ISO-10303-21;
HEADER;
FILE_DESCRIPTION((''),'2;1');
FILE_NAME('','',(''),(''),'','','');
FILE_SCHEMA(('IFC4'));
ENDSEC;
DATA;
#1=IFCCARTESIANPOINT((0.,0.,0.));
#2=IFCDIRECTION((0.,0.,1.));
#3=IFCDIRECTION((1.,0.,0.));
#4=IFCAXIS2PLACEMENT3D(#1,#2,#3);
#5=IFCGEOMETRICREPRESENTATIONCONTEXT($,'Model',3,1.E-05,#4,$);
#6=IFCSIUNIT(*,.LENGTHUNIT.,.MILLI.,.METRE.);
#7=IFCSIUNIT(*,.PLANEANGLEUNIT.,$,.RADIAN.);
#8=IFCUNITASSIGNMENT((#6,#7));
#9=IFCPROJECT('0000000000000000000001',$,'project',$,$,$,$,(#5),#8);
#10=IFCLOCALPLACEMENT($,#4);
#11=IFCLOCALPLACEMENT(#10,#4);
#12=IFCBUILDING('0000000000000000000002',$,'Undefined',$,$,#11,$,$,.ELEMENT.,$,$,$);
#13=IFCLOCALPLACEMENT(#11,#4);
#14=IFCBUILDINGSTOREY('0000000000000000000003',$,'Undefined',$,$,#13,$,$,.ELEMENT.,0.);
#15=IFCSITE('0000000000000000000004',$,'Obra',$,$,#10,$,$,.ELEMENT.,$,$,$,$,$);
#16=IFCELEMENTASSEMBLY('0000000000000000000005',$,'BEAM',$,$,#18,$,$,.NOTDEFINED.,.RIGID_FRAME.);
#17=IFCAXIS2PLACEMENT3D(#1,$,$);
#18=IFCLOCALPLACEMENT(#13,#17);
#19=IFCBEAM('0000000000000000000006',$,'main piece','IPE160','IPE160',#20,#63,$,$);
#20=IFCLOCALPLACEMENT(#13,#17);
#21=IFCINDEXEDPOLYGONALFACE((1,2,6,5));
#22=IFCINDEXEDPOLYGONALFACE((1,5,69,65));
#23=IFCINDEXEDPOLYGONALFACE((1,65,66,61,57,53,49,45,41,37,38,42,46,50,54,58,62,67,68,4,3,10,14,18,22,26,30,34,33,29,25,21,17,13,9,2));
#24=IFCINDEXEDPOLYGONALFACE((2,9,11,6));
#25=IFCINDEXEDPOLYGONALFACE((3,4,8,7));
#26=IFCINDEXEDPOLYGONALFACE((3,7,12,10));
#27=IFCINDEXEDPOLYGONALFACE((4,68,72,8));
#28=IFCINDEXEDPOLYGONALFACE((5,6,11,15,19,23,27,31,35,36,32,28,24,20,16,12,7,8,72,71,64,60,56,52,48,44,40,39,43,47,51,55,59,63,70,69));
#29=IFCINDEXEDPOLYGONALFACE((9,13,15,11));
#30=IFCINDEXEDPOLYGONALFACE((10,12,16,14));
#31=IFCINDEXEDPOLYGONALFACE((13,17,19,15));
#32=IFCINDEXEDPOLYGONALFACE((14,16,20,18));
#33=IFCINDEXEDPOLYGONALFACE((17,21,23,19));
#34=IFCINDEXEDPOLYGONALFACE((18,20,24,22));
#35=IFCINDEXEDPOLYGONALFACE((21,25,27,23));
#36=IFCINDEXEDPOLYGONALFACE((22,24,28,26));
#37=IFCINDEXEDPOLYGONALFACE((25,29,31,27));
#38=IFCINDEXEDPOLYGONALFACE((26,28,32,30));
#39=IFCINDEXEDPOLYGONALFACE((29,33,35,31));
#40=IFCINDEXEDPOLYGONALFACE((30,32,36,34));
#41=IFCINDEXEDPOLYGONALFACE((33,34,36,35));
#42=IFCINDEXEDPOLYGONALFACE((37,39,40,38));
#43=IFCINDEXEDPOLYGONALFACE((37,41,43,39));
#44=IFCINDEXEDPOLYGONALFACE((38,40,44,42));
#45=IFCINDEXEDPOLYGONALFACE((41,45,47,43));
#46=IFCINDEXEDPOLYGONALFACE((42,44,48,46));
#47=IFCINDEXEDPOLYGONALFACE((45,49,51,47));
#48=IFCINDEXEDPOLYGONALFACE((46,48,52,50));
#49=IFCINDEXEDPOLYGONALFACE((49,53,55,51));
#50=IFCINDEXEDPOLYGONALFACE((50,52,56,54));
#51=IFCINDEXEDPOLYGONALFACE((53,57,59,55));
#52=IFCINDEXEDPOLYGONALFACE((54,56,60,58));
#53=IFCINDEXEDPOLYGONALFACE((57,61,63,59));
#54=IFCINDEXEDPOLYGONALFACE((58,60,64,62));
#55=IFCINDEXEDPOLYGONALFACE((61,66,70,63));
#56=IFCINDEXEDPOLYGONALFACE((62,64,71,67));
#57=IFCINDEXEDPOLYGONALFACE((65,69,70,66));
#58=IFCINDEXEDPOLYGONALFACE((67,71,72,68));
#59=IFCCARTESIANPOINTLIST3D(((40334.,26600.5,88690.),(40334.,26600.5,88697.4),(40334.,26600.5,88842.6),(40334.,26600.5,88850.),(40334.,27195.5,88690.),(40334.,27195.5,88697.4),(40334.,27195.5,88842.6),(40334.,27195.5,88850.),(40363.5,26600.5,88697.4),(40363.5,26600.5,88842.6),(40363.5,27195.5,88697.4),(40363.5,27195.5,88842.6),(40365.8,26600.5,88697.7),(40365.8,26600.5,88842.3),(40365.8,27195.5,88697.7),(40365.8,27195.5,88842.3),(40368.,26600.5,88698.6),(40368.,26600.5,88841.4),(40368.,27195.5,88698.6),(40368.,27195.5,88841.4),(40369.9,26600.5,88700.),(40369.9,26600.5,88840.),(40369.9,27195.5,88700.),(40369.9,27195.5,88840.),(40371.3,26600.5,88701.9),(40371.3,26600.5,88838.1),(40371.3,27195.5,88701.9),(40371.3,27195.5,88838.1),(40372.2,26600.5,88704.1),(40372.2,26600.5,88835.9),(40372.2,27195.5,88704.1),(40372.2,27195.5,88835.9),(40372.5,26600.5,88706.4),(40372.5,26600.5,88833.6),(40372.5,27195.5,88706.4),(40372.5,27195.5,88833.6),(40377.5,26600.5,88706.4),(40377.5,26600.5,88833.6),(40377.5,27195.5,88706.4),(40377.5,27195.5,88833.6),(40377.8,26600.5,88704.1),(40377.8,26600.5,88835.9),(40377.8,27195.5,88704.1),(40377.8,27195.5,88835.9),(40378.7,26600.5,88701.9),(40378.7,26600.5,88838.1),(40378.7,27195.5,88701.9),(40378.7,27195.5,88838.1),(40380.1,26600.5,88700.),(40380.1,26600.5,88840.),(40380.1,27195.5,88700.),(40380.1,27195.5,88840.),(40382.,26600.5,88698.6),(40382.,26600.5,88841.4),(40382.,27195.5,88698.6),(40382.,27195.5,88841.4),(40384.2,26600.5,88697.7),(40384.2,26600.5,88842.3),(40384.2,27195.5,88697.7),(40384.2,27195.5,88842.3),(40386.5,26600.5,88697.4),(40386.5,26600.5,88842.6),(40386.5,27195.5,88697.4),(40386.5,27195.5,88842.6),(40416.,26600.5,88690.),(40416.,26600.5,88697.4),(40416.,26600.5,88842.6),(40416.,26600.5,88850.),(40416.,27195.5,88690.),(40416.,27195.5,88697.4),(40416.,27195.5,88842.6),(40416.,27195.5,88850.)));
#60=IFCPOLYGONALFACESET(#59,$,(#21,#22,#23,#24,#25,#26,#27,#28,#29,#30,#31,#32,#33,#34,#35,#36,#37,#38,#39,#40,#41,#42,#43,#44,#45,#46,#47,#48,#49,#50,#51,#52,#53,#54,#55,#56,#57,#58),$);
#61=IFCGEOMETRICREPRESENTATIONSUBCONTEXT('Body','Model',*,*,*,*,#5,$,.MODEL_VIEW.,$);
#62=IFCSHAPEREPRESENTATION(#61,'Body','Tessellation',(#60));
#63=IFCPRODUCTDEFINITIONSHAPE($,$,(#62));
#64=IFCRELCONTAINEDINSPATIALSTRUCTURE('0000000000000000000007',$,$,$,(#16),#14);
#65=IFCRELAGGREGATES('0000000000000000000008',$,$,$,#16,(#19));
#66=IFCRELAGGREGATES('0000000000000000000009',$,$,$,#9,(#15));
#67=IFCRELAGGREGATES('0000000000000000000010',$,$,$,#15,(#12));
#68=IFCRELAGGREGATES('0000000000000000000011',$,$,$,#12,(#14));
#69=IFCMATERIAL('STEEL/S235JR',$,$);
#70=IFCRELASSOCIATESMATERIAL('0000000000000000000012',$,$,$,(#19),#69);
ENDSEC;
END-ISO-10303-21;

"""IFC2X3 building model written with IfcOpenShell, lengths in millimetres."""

from ifc_helpers import new_model, si_unit, frame, origin_with_axes, origin_2d_with_axis, place, context, subcontext, project, spatial, i_section, extrude, material, element, aggregate, save


model = new_model("IFC2X3")

# Units and contexts
model_context = context("Model", 3, precision=1e-05, world=origin_with_axes())
body_context = subcontext(model_context, "Body", "Model", "MODEL_VIEW")
ifc_project = project(units=[si_unit("LENGTHUNIT", "METRE", prefix="MILLI"), si_unit("PLANEANGLEUNIT", "RADIAN")], contexts=[model_context])

# Site, building, storey
site_placement = place(None, origin_with_axes())
site = spatial("IfcSite", under=ifc_project, at=site_placement, Name="Obra", CompositionType="ELEMENT")
building_placement = place(site_placement, origin_with_axes())
building = spatial("IfcBuilding", under=site, at=building_placement, Name="Undefined", CompositionType="ELEMENT")
storey_placement = place(building_placement, origin_with_axes())
storey = spatial("IfcBuildingStorey", under=building, at=storey_placement, Name="Undefined", CompositionType="ELEMENT", Elevation=0.0)

# Element assembly, beam
ifc_material_1 = material(Name="STEEL/S235JR")
assembly_1_placement = place(storey_placement, origin_with_axes())
assembly_1 = element("IfcElementAssembly", 1, at=assembly_1_placement, inside=storey, Name="BEAM", AssemblyPlace="NOTDEFINED", PredefinedType="RIGID_FRAME")
beam_1_placement = place(assembly_1_placement, frame((40375.0, 26600.5, 88770.0), z_axis=(0.0, 0.0, 1.0), x_axis=(0.0, 1.0, 0.0)))
beam_1 = element("IfcBeam", 2, at=beam_1_placement, material=ifc_material_1, Name="main piece", Description="IPE160", ObjectType="IPE160", context=body_context, shape_type="SweptSolid", body=[
    extrude(i_section(OverallWidth=82.0, OverallDepth=160.0, WebThickness=5.0, FlangeThickness=7.4, FilletRadius=9.0, at=origin_2d_with_axis()), frame((595.0, 0.0, 0.0), z_axis=(-1.0, 0.0, 0.0), x_axis=(0.0, -1.0, 0.0)), (0.0, 0.0, 1.0), 595.0),
])
aggregate(assembly_1, [beam_1])

save(model, "model.ifc")
